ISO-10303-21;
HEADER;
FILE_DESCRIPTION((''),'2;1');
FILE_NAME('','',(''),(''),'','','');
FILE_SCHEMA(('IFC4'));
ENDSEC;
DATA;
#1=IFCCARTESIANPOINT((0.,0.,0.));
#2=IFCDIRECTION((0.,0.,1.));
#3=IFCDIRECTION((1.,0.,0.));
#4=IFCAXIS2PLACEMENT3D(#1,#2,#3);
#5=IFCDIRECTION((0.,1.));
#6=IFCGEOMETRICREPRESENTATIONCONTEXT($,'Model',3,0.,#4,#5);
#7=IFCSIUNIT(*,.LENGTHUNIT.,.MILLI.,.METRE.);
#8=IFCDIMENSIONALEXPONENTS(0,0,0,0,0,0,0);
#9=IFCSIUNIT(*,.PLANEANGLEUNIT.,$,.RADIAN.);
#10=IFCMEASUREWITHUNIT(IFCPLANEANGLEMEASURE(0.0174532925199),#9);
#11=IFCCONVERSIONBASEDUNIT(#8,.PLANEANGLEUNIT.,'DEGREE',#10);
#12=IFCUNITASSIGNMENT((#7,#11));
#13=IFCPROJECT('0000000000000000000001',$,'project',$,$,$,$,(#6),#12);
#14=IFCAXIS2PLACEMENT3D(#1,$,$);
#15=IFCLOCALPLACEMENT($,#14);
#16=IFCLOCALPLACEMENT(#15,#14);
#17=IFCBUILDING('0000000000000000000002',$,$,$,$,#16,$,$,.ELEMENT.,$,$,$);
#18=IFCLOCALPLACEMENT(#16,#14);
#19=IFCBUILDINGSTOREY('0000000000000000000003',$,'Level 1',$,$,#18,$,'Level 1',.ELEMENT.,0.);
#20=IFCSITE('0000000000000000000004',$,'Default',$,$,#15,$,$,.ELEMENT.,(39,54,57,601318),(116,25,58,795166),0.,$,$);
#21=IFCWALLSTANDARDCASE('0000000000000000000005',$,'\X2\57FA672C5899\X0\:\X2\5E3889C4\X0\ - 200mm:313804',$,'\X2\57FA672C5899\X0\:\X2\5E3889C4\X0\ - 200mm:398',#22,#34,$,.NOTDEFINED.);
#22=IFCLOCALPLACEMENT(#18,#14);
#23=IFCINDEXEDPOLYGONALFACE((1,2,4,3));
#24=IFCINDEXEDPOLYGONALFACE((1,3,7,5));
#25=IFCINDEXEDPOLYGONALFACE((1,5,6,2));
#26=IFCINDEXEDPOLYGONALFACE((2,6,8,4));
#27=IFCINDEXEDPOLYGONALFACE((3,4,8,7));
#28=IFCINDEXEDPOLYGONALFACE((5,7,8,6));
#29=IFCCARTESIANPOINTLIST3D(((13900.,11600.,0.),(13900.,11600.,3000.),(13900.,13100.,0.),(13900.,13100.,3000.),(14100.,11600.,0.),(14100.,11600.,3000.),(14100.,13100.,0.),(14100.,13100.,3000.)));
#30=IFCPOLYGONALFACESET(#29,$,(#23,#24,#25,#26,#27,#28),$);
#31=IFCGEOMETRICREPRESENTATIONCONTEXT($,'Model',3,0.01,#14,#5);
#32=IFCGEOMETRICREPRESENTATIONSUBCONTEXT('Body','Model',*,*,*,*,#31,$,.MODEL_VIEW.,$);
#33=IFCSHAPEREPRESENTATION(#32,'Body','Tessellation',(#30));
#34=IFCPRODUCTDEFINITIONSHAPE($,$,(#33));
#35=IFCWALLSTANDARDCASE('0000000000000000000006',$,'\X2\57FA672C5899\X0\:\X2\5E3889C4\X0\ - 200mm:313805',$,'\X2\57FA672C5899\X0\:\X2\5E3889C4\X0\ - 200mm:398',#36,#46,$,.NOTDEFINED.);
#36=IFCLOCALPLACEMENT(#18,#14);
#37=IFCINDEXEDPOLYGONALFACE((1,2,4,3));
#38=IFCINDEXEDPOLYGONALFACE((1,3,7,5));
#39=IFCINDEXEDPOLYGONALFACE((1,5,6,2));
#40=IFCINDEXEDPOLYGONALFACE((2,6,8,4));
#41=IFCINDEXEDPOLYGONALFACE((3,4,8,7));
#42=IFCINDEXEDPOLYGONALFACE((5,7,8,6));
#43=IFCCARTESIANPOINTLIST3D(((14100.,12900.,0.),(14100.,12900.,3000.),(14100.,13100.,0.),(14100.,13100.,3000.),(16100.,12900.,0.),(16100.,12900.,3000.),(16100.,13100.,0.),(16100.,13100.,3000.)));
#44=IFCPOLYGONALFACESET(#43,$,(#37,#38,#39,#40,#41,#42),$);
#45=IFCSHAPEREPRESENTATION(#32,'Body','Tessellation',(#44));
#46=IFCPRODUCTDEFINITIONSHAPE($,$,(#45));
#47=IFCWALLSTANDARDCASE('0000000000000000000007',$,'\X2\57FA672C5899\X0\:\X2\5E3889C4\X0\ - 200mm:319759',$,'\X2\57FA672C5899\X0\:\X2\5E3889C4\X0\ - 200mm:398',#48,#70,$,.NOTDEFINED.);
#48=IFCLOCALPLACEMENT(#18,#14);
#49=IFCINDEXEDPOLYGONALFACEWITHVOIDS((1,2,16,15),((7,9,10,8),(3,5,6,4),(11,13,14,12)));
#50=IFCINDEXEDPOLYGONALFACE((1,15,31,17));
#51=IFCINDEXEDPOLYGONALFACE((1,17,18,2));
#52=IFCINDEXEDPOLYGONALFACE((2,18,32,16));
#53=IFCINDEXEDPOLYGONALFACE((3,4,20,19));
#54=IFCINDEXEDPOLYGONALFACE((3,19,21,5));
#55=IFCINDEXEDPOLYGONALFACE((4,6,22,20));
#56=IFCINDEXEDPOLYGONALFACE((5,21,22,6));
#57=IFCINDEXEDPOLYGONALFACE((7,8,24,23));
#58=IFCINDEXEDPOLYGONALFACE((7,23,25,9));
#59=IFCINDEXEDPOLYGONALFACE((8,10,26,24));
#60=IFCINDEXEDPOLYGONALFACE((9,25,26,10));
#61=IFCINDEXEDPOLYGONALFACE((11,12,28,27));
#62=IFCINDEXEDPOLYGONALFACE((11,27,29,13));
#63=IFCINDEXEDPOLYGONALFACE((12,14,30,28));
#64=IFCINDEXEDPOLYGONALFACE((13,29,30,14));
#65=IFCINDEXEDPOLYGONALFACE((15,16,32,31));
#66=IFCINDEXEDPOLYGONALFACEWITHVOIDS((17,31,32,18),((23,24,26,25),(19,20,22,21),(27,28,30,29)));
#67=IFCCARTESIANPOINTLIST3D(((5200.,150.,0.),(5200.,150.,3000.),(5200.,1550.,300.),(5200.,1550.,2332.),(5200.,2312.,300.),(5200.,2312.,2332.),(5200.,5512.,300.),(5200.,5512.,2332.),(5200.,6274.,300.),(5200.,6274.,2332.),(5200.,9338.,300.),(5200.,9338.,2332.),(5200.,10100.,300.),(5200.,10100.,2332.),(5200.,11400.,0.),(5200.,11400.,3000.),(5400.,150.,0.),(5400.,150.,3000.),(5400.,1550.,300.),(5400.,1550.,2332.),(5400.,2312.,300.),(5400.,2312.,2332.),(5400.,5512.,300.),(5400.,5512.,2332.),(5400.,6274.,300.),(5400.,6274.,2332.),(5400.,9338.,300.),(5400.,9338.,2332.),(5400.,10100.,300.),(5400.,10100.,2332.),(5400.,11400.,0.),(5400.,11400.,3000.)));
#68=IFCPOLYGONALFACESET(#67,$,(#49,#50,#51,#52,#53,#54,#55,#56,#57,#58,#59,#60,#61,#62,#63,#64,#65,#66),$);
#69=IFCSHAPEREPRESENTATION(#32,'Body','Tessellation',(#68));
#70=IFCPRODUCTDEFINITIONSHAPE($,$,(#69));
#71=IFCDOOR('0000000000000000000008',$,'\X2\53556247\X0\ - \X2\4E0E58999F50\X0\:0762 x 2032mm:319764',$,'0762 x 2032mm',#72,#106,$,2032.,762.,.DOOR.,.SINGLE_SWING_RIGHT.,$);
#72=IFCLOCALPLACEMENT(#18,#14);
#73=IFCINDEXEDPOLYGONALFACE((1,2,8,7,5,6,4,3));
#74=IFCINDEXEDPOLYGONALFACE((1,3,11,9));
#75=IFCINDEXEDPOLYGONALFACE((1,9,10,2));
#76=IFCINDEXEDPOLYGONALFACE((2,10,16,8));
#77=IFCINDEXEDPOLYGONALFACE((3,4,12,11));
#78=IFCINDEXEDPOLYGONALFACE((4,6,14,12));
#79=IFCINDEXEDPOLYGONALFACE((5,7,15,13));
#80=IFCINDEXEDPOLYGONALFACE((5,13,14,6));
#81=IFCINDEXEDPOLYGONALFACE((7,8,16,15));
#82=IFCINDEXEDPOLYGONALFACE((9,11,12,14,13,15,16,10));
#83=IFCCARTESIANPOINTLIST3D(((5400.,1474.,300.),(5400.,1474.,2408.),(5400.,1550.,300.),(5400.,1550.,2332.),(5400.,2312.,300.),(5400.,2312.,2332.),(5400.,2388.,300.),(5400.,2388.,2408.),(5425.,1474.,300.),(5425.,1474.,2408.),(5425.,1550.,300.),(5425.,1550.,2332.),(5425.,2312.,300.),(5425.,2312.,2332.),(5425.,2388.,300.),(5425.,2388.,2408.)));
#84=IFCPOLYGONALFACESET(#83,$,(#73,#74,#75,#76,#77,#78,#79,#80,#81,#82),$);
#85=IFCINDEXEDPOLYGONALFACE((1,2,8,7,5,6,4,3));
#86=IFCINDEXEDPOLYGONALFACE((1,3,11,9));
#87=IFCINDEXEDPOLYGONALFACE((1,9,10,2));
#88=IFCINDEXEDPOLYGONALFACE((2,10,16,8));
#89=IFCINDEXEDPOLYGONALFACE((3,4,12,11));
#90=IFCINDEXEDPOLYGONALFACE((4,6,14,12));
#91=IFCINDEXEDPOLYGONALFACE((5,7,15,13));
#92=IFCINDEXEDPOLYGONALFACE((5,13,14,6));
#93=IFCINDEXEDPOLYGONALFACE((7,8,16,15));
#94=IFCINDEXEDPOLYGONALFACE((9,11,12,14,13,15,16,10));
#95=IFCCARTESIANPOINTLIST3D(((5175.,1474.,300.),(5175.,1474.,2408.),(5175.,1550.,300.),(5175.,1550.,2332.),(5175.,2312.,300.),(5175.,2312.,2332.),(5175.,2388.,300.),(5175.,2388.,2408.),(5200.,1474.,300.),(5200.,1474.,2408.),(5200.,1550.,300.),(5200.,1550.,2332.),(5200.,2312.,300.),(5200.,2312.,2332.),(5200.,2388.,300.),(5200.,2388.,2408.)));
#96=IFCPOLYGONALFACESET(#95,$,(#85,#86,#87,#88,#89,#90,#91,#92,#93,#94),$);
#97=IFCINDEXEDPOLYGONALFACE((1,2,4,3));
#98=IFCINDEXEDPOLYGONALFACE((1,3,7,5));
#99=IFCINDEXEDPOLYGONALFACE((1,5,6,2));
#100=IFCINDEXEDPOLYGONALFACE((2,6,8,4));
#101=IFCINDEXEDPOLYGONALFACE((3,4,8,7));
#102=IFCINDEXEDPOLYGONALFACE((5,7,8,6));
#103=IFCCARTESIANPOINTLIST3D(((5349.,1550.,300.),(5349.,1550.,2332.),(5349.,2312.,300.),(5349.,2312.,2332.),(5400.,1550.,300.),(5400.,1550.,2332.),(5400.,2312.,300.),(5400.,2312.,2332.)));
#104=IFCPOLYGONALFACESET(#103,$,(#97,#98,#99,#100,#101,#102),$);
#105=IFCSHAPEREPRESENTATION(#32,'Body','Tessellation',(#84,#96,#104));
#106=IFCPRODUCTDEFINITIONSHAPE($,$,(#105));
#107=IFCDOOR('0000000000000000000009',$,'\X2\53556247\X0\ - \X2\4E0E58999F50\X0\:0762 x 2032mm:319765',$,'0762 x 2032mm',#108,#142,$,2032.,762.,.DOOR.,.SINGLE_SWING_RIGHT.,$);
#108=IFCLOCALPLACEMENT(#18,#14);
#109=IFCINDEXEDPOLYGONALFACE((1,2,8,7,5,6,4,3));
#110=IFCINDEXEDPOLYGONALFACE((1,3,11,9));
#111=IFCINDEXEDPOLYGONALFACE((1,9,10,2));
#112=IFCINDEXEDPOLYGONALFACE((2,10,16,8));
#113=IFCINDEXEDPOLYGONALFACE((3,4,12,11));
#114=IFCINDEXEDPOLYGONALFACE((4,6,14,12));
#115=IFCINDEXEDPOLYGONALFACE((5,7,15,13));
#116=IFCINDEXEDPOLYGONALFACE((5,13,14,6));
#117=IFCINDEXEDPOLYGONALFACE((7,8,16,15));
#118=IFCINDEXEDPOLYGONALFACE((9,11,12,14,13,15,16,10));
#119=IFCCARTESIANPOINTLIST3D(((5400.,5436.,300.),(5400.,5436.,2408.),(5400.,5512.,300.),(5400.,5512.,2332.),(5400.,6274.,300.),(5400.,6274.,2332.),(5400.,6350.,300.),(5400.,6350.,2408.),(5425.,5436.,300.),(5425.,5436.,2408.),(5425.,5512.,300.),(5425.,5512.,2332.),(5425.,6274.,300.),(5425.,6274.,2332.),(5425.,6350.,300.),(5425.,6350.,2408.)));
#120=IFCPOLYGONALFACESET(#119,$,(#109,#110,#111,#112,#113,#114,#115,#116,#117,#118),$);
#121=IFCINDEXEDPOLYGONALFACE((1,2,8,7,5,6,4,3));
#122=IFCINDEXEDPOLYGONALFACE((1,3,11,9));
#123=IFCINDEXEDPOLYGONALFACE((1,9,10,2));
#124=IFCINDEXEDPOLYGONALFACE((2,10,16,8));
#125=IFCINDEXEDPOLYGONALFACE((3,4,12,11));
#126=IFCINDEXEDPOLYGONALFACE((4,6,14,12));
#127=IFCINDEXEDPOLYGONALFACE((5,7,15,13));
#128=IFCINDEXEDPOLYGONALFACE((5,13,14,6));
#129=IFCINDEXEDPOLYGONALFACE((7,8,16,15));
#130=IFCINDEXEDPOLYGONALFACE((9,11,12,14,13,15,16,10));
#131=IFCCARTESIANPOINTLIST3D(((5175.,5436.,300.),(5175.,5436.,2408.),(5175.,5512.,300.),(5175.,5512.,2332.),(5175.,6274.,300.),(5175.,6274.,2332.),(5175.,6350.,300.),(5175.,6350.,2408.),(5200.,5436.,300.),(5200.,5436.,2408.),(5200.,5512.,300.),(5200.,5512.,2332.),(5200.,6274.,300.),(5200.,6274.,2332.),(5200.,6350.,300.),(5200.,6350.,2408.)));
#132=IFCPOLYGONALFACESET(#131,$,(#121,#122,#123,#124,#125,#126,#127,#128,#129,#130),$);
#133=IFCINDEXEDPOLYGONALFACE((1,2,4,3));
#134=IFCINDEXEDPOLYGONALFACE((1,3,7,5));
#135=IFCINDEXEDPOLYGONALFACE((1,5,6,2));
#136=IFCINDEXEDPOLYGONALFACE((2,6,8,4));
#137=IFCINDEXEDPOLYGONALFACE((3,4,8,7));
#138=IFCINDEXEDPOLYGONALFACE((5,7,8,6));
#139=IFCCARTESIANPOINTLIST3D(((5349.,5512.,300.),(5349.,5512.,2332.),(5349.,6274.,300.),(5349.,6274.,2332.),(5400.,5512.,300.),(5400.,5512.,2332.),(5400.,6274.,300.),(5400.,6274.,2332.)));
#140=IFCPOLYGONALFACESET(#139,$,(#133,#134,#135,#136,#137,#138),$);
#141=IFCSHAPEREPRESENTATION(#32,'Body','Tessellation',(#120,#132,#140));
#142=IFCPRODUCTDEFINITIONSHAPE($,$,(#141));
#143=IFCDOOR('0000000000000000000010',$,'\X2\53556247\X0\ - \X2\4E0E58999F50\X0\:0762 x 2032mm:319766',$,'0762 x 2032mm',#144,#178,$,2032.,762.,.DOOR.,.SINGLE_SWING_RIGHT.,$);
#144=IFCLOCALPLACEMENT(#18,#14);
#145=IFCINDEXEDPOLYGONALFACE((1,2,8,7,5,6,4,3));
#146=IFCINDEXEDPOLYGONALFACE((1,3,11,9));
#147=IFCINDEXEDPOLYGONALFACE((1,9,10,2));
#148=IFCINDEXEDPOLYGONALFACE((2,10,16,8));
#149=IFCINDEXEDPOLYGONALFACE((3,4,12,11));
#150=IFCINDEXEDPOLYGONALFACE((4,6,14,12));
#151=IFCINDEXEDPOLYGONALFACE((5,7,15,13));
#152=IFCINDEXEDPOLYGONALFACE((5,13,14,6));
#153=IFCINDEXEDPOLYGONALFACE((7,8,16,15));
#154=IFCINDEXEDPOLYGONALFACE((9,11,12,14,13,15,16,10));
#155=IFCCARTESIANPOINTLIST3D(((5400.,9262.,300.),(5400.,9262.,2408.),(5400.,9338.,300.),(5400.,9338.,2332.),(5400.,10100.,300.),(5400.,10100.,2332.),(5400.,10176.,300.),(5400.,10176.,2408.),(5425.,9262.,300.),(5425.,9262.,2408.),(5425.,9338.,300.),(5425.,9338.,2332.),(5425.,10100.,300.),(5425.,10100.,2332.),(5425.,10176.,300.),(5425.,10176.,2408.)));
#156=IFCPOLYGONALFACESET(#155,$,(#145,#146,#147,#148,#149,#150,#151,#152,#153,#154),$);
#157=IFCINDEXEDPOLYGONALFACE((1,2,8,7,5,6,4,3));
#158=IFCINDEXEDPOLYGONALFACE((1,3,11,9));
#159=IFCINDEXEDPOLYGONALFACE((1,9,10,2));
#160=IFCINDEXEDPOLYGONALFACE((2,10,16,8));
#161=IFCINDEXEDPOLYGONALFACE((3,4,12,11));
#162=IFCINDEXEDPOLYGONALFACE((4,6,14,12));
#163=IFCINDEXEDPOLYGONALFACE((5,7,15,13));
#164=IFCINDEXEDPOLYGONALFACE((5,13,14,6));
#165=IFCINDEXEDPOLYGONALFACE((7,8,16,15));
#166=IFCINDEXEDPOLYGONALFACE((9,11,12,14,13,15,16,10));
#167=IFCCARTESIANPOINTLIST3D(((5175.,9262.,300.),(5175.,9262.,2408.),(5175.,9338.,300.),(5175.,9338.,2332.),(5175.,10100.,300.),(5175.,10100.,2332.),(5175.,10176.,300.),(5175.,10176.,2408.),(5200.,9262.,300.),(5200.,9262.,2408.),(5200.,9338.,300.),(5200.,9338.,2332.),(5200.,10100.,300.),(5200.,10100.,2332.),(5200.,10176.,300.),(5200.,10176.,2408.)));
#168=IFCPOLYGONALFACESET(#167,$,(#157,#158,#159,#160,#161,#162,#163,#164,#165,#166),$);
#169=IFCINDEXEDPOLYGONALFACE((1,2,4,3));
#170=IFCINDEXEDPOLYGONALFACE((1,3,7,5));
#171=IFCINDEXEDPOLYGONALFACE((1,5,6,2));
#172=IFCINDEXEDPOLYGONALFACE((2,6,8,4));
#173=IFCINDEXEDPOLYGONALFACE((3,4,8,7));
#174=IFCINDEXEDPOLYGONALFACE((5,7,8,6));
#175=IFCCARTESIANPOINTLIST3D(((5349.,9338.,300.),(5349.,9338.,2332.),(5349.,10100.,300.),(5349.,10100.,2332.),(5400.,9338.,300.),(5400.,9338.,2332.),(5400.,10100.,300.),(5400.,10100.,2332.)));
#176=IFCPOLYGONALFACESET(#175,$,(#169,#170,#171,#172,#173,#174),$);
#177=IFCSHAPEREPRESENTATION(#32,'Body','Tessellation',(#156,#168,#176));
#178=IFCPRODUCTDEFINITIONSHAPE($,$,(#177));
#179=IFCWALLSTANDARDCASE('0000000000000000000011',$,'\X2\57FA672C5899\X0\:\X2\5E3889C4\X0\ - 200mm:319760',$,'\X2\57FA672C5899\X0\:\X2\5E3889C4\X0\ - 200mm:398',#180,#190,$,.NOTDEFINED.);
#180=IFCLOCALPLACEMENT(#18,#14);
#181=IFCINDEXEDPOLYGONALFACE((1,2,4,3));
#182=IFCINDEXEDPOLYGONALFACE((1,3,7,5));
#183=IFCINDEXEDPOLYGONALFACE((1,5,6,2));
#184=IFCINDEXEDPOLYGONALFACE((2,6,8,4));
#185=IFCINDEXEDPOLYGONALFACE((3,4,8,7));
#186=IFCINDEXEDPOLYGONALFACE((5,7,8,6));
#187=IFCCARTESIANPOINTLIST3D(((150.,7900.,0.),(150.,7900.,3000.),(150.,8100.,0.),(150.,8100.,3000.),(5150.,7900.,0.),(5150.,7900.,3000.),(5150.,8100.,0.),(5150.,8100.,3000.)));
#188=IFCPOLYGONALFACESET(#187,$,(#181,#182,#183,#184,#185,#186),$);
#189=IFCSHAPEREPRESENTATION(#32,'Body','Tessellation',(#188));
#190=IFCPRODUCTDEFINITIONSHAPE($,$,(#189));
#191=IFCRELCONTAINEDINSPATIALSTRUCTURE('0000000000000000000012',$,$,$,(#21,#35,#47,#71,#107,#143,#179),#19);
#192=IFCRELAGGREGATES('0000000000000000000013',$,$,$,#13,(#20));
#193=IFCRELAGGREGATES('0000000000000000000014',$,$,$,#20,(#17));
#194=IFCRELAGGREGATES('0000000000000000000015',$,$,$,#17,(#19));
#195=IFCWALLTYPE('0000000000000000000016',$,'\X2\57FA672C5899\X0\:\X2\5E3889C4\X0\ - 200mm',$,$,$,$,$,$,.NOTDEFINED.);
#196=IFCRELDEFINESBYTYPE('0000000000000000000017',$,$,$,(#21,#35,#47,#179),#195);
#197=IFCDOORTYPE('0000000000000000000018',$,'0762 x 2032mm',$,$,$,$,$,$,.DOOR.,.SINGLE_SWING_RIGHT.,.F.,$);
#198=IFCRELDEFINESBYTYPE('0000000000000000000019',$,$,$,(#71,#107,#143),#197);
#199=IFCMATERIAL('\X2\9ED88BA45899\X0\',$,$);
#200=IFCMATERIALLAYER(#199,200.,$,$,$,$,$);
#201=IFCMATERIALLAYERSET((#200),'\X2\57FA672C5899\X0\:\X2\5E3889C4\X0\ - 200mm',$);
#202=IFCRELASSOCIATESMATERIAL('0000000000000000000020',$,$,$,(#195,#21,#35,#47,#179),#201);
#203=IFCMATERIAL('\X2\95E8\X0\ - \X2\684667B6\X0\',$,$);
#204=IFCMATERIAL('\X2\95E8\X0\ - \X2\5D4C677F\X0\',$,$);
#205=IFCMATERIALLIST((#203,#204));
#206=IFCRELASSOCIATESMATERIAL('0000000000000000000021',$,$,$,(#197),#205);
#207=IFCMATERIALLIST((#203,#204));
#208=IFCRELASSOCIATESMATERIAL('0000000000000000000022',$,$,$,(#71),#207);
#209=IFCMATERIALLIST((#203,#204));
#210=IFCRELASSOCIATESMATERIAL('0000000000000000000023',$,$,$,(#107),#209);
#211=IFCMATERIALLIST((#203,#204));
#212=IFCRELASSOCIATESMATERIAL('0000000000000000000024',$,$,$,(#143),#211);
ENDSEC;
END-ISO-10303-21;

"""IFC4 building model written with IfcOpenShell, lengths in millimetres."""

from ifc_helpers import new_model, entity, si_unit, converted_unit, direction, frame, frame_2d, origin, origin_with_axes, origin_2d_with_axis, place, context, subcontext, project, spatial, polyline, rectangle, outline, extrude, source, transform, mapped, material, material_list, layer, layer_set, layer_usage, type_object, type_shapes, element, fill, save


model = new_model("IFC4")

# Units and contexts
model_context_1 = context("Model", 3, precision=0.0, world=origin_with_axes(), true_north=direction((0.0, 1.0)))
model_context_2 = context("Model", 3, precision=0.01, world=origin(), true_north=direction((0.0, 1.0)))
body_context = subcontext(model_context_2, "Body", "Model", "MODEL_VIEW")
ifc_project = project(units=[si_unit("LENGTHUNIT", "METRE", prefix="MILLI"), converted_unit("PLANEANGLEUNIT", "DEGREE", entity("IfcPlaneAngleMeasure", 0.0174532925199), si_unit("PLANEANGLEUNIT", "RADIAN"), dimensions=[0, 0, 0, 0, 0, 0, 0])], contexts=[model_context_1])

# Site, building, storey
site_placement = place(None, origin())
site = spatial("IfcSite", under=ifc_project, at=site_placement, Name="Default", CompositionType="ELEMENT", RefLatitude=(39, 54, 57, 601318), RefLongitude=(116, 25, 58, 795166), RefElevation=0.0)
building_placement = place(site_placement, origin())
building = spatial("IfcBuilding", under=site, at=building_placement, CompositionType="ELEMENT")
storey_placement = place(building_placement, origin())
storey = spatial("IfcBuildingStorey", under=building, at=storey_placement, Name="Level 1", LongName="Level 1", CompositionType="ELEMENT", Elevation=0.0)

# Shared definitions
ifc_material_1 = material(Name="默认墙")
ifc_layer = layer(ifc_material_1, 200.0)
ifc_layer_set = layer_set([ifc_layer], Name="基本墙:常规 - 200mm")
wall_type = type_object("IfcWallType", Name="基本墙:常规 - 200mm", PredefinedType="NOTDEFINED", material=ifc_layer_set)

# Walls
ifc_layer_usage_1 = layer_usage(ifc_layer_set, "AXIS2", "NEGATIVE", 100.0)
wall_1_placement = place(storey_placement, frame((14000.0, 11600.0, 0.0), z_axis=(0.0, 0.0, 1.0), x_axis=(0.0, 1.0, 0.0)))
element("IfcWallStandardCase", 1, at=wall_1_placement, inside=storey, type_object=wall_type, material=ifc_layer_usage_1, Name="基本墙:常规 - 200mm:313804", ObjectType="基本墙:常规 - 200mm:398", PredefinedType="NOTDEFINED", context=body_context, shape_type="SweptSolid", body=[
    extrude(rectangle(XDim=1500.0, YDim=200.0, at=frame_2d((750.0, 0.0), x_axis=(-1.0, 0.0))), origin(), (0.0, 0.0, 1.0), 3000.0),
])
ifc_layer_usage_2 = layer_usage(ifc_layer_set, "AXIS2", "NEGATIVE", 100.0)
wall_2_placement = place(storey_placement, frame((14100.0, 13000.0, 0.0)))
element("IfcWallStandardCase", 2, at=wall_2_placement, inside=storey, type_object=wall_type, material=ifc_layer_usage_2, Name="基本墙:常规 - 200mm:313805", ObjectType="基本墙:常规 - 200mm:398", PredefinedType="NOTDEFINED", context=body_context, shape_type="SweptSolid", body=[
    extrude(rectangle(XDim=2000.0, YDim=200.0, at=frame_2d((1000.0, 0.0), x_axis=(-1.0, 0.0))), origin(), (0.0, 0.0, 1.0), 3000.0),
])

# Wall, openings, doors
ifc_layer_usage_3 = layer_usage(ifc_layer_set, "AXIS2", "NEGATIVE", 100.0)
wall_3_placement = place(storey_placement, frame((5300.0, 11400.0, 0.0), z_axis=(0.0, 0.0, 1.0), x_axis=(0.0, -1.0, 0.0)))
wall_3 = element("IfcWallStandardCase", 3, at=wall_3_placement, inside=storey, type_object=wall_type, material=ifc_layer_usage_3, Name="基本墙:常规 - 200mm:319759", ObjectType="基本墙:常规 - 200mm:398", PredefinedType="NOTDEFINED", context=body_context, shape_type="SweptSolid", body=[
    extrude(rectangle(XDim=11250.0, YDim=200.0, at=frame_2d((5625.0, 0.0), x_axis=(-1.0, 0.0))), origin(), (0.0, 0.0, 1.0), 3000.0),
])
opening_1_placement = place(wall_3_placement, frame((9088.0, -100.0, 300.0)))
opening_1 = element("IfcOpeningElement", 4, at=opening_1_placement, cuts=wall_3, ObjectType="Opening", PredefinedType="OPENING", context=body_context, shape_type="SweptSolid", body=[
    extrude(rectangle(XDim=762.0, YDim=2032.0, at=frame_2d((1016.0, 381.0), x_axis=(0.0, 1.0))), frame((0.0, 0.0, 0.0), z_axis=(0.0, 1.0, 0.0), x_axis=(0.0, 0.0, 1.0)), (0.0, 0.0, 1.0), 200.0),
])
opening_2_placement = place(wall_3_placement, frame((5126.0, -100.0, 300.0)))
opening_2 = element("IfcOpeningElement", 5, at=opening_2_placement, cuts=wall_3, ObjectType="Opening", PredefinedType="OPENING", context=body_context, shape_type="SweptSolid", body=[
    extrude(rectangle(XDim=762.0, YDim=2032.0, at=frame_2d((1016.0, 381.0), x_axis=(0.0, 1.0))), frame((0.0, 0.0, 0.0), z_axis=(0.0, 1.0, 0.0), x_axis=(0.0, 0.0, 1.0)), (0.0, 0.0, 1.0), 200.0),
])
opening_3_placement = place(wall_3_placement, frame((1300.0, -100.0, 300.0)))
opening_3 = element("IfcOpeningElement", 6, at=opening_3_placement, cuts=wall_3, ObjectType="Opening", PredefinedType="OPENING", context=body_context, shape_type="SweptSolid", body=[
    extrude(rectangle(XDim=762.0, YDim=2032.0, at=frame_2d((1016.0, 381.0), x_axis=(0.0, 1.0))), frame((0.0, 0.0, 0.0), z_axis=(0.0, 1.0, 0.0), x_axis=(0.0, 0.0, 1.0)), (0.0, 0.0, 1.0), 200.0),
])
ifc_material_2 = material(Name="门 - 框架")
ifc_material_3 = material(Name="门 - 嵌板")
ifc_material_list_1 = material_list([ifc_material_2, ifc_material_3])
ifc_material_list_2 = material_list([ifc_material_2, ifc_material_3])
door_type_1 = type_object("IfcDoorType", Name="0762 x 2032mm", OperationType="SINGLE_SWING_RIGHT", ParameterTakesPrecedence=False, PredefinedType="DOOR", material=ifc_material_list_2)
shared_shape_1 = source(origin(), body_context, "Body", "SweptSolid", [
    extrude(outline(polyline([(-457.0, -1073.0), (457.0, -1073.0), (457.0, 1035.0), (381.0, 1035.0), (381.0, -997.0), (-381.0, -997.0), (-381.0, 1035.0), (-457.0, 1035.0), (-457.0, -1073.0)])), frame((381.0, 200.0, 1035.0), z_axis=(0.0, 1.0, 0.0), x_axis=(1.0, 0.0, 0.0)), (0.0, 0.0, 1.0), 25.0),
    extrude(outline(polyline([(-1073.0, -457.0), (1035.0, -457.0), (1035.0, -381.0), (-997.0, -381.0), (-997.0, 381.0), (1035.0, 381.0), (1035.0, 457.0), (-1073.0, 457.0), (-1073.0, -457.0)])), frame((381.0, -25.0, 1035.0), z_axis=(0.0, 1.0, 0.0), x_axis=(0.0, 0.0, -1.0)), (0.0, 0.0, 1.0), 25.0),
    extrude(rectangle(XDim=51.0, YDim=762.0, at=origin_2d_with_axis()), frame((381.0, 174.5, 0.0), z_axis=(0.0, 0.0, 1.0), x_axis=(0.0, 1.0, 0.0)), (0.0, 0.0, 1.0), 2032.0),
])
type_shapes(door_type_1, [shared_shape_1])
door_1_placement = place(opening_1_placement, origin())
door_1 = element("IfcDoor", 7, at=door_1_placement, inside=storey, type_object=door_type_1, material=ifc_material_list_1, Name="单扇 - 与墙齐:0762 x 2032mm:319764", ObjectType="0762 x 2032mm", OperationType="SINGLE_SWING_RIGHT", OverallHeight=2032.0, OverallWidth=762.0, PredefinedType="DOOR", context=body_context, shape_type="MappedRepresentation", body=[
    mapped(shared_shape_1, transform((0.0, 0.0, 0.0), scale=1.0)),
])
fill(opening_1, door_1)
ifc_material_list_3 = material_list([ifc_material_2, ifc_material_3])
door_2_placement = place(opening_2_placement, origin())
door_2 = element("IfcDoor", 8, at=door_2_placement, inside=storey, type_object=door_type_1, material=ifc_material_list_3, Name="单扇 - 与墙齐:0762 x 2032mm:319765", ObjectType="0762 x 2032mm", OperationType="SINGLE_SWING_RIGHT", OverallHeight=2032.0, OverallWidth=762.0, PredefinedType="DOOR", context=body_context, shape_type="MappedRepresentation", body=[
    mapped(shared_shape_1, transform((0.0, 0.0, 0.0), scale=1.0)),
])
fill(opening_2, door_2)
ifc_material_list_4 = material_list([ifc_material_2, ifc_material_3])
door_3_placement = place(opening_3_placement, origin())
door_3 = element("IfcDoor", 9, at=door_3_placement, inside=storey, type_object=door_type_1, material=ifc_material_list_4, Name="单扇 - 与墙齐:0762 x 2032mm:319766", ObjectType="0762 x 2032mm", OperationType="SINGLE_SWING_RIGHT", OverallHeight=2032.0, OverallWidth=762.0, PredefinedType="DOOR", context=body_context, shape_type="MappedRepresentation", body=[
    mapped(shared_shape_1, transform((0.0, 0.0, 0.0), scale=1.0)),
])
fill(opening_3, door_3)

# Wall
ifc_layer_usage_4 = layer_usage(ifc_layer_set, "AXIS2", "NEGATIVE", 100.0)
wall_4_placement = place(storey_placement, frame((150.0, 8000.0, 0.0)))
element("IfcWallStandardCase", 10, at=wall_4_placement, inside=storey, type_object=wall_type, material=ifc_layer_usage_4, Name="基本墙:常规 - 200mm:319760", ObjectType="基本墙:常规 - 200mm:398", PredefinedType="NOTDEFINED", context=body_context, shape_type="SweptSolid", body=[
    extrude(rectangle(XDim=5000.0, YDim=200.0, at=frame_2d((2500.0, 0.0), x_axis=(-1.0, 0.0))), origin(), (0.0, 0.0, 1.0), 3000.0),
])

save(model, "model.ifc")
